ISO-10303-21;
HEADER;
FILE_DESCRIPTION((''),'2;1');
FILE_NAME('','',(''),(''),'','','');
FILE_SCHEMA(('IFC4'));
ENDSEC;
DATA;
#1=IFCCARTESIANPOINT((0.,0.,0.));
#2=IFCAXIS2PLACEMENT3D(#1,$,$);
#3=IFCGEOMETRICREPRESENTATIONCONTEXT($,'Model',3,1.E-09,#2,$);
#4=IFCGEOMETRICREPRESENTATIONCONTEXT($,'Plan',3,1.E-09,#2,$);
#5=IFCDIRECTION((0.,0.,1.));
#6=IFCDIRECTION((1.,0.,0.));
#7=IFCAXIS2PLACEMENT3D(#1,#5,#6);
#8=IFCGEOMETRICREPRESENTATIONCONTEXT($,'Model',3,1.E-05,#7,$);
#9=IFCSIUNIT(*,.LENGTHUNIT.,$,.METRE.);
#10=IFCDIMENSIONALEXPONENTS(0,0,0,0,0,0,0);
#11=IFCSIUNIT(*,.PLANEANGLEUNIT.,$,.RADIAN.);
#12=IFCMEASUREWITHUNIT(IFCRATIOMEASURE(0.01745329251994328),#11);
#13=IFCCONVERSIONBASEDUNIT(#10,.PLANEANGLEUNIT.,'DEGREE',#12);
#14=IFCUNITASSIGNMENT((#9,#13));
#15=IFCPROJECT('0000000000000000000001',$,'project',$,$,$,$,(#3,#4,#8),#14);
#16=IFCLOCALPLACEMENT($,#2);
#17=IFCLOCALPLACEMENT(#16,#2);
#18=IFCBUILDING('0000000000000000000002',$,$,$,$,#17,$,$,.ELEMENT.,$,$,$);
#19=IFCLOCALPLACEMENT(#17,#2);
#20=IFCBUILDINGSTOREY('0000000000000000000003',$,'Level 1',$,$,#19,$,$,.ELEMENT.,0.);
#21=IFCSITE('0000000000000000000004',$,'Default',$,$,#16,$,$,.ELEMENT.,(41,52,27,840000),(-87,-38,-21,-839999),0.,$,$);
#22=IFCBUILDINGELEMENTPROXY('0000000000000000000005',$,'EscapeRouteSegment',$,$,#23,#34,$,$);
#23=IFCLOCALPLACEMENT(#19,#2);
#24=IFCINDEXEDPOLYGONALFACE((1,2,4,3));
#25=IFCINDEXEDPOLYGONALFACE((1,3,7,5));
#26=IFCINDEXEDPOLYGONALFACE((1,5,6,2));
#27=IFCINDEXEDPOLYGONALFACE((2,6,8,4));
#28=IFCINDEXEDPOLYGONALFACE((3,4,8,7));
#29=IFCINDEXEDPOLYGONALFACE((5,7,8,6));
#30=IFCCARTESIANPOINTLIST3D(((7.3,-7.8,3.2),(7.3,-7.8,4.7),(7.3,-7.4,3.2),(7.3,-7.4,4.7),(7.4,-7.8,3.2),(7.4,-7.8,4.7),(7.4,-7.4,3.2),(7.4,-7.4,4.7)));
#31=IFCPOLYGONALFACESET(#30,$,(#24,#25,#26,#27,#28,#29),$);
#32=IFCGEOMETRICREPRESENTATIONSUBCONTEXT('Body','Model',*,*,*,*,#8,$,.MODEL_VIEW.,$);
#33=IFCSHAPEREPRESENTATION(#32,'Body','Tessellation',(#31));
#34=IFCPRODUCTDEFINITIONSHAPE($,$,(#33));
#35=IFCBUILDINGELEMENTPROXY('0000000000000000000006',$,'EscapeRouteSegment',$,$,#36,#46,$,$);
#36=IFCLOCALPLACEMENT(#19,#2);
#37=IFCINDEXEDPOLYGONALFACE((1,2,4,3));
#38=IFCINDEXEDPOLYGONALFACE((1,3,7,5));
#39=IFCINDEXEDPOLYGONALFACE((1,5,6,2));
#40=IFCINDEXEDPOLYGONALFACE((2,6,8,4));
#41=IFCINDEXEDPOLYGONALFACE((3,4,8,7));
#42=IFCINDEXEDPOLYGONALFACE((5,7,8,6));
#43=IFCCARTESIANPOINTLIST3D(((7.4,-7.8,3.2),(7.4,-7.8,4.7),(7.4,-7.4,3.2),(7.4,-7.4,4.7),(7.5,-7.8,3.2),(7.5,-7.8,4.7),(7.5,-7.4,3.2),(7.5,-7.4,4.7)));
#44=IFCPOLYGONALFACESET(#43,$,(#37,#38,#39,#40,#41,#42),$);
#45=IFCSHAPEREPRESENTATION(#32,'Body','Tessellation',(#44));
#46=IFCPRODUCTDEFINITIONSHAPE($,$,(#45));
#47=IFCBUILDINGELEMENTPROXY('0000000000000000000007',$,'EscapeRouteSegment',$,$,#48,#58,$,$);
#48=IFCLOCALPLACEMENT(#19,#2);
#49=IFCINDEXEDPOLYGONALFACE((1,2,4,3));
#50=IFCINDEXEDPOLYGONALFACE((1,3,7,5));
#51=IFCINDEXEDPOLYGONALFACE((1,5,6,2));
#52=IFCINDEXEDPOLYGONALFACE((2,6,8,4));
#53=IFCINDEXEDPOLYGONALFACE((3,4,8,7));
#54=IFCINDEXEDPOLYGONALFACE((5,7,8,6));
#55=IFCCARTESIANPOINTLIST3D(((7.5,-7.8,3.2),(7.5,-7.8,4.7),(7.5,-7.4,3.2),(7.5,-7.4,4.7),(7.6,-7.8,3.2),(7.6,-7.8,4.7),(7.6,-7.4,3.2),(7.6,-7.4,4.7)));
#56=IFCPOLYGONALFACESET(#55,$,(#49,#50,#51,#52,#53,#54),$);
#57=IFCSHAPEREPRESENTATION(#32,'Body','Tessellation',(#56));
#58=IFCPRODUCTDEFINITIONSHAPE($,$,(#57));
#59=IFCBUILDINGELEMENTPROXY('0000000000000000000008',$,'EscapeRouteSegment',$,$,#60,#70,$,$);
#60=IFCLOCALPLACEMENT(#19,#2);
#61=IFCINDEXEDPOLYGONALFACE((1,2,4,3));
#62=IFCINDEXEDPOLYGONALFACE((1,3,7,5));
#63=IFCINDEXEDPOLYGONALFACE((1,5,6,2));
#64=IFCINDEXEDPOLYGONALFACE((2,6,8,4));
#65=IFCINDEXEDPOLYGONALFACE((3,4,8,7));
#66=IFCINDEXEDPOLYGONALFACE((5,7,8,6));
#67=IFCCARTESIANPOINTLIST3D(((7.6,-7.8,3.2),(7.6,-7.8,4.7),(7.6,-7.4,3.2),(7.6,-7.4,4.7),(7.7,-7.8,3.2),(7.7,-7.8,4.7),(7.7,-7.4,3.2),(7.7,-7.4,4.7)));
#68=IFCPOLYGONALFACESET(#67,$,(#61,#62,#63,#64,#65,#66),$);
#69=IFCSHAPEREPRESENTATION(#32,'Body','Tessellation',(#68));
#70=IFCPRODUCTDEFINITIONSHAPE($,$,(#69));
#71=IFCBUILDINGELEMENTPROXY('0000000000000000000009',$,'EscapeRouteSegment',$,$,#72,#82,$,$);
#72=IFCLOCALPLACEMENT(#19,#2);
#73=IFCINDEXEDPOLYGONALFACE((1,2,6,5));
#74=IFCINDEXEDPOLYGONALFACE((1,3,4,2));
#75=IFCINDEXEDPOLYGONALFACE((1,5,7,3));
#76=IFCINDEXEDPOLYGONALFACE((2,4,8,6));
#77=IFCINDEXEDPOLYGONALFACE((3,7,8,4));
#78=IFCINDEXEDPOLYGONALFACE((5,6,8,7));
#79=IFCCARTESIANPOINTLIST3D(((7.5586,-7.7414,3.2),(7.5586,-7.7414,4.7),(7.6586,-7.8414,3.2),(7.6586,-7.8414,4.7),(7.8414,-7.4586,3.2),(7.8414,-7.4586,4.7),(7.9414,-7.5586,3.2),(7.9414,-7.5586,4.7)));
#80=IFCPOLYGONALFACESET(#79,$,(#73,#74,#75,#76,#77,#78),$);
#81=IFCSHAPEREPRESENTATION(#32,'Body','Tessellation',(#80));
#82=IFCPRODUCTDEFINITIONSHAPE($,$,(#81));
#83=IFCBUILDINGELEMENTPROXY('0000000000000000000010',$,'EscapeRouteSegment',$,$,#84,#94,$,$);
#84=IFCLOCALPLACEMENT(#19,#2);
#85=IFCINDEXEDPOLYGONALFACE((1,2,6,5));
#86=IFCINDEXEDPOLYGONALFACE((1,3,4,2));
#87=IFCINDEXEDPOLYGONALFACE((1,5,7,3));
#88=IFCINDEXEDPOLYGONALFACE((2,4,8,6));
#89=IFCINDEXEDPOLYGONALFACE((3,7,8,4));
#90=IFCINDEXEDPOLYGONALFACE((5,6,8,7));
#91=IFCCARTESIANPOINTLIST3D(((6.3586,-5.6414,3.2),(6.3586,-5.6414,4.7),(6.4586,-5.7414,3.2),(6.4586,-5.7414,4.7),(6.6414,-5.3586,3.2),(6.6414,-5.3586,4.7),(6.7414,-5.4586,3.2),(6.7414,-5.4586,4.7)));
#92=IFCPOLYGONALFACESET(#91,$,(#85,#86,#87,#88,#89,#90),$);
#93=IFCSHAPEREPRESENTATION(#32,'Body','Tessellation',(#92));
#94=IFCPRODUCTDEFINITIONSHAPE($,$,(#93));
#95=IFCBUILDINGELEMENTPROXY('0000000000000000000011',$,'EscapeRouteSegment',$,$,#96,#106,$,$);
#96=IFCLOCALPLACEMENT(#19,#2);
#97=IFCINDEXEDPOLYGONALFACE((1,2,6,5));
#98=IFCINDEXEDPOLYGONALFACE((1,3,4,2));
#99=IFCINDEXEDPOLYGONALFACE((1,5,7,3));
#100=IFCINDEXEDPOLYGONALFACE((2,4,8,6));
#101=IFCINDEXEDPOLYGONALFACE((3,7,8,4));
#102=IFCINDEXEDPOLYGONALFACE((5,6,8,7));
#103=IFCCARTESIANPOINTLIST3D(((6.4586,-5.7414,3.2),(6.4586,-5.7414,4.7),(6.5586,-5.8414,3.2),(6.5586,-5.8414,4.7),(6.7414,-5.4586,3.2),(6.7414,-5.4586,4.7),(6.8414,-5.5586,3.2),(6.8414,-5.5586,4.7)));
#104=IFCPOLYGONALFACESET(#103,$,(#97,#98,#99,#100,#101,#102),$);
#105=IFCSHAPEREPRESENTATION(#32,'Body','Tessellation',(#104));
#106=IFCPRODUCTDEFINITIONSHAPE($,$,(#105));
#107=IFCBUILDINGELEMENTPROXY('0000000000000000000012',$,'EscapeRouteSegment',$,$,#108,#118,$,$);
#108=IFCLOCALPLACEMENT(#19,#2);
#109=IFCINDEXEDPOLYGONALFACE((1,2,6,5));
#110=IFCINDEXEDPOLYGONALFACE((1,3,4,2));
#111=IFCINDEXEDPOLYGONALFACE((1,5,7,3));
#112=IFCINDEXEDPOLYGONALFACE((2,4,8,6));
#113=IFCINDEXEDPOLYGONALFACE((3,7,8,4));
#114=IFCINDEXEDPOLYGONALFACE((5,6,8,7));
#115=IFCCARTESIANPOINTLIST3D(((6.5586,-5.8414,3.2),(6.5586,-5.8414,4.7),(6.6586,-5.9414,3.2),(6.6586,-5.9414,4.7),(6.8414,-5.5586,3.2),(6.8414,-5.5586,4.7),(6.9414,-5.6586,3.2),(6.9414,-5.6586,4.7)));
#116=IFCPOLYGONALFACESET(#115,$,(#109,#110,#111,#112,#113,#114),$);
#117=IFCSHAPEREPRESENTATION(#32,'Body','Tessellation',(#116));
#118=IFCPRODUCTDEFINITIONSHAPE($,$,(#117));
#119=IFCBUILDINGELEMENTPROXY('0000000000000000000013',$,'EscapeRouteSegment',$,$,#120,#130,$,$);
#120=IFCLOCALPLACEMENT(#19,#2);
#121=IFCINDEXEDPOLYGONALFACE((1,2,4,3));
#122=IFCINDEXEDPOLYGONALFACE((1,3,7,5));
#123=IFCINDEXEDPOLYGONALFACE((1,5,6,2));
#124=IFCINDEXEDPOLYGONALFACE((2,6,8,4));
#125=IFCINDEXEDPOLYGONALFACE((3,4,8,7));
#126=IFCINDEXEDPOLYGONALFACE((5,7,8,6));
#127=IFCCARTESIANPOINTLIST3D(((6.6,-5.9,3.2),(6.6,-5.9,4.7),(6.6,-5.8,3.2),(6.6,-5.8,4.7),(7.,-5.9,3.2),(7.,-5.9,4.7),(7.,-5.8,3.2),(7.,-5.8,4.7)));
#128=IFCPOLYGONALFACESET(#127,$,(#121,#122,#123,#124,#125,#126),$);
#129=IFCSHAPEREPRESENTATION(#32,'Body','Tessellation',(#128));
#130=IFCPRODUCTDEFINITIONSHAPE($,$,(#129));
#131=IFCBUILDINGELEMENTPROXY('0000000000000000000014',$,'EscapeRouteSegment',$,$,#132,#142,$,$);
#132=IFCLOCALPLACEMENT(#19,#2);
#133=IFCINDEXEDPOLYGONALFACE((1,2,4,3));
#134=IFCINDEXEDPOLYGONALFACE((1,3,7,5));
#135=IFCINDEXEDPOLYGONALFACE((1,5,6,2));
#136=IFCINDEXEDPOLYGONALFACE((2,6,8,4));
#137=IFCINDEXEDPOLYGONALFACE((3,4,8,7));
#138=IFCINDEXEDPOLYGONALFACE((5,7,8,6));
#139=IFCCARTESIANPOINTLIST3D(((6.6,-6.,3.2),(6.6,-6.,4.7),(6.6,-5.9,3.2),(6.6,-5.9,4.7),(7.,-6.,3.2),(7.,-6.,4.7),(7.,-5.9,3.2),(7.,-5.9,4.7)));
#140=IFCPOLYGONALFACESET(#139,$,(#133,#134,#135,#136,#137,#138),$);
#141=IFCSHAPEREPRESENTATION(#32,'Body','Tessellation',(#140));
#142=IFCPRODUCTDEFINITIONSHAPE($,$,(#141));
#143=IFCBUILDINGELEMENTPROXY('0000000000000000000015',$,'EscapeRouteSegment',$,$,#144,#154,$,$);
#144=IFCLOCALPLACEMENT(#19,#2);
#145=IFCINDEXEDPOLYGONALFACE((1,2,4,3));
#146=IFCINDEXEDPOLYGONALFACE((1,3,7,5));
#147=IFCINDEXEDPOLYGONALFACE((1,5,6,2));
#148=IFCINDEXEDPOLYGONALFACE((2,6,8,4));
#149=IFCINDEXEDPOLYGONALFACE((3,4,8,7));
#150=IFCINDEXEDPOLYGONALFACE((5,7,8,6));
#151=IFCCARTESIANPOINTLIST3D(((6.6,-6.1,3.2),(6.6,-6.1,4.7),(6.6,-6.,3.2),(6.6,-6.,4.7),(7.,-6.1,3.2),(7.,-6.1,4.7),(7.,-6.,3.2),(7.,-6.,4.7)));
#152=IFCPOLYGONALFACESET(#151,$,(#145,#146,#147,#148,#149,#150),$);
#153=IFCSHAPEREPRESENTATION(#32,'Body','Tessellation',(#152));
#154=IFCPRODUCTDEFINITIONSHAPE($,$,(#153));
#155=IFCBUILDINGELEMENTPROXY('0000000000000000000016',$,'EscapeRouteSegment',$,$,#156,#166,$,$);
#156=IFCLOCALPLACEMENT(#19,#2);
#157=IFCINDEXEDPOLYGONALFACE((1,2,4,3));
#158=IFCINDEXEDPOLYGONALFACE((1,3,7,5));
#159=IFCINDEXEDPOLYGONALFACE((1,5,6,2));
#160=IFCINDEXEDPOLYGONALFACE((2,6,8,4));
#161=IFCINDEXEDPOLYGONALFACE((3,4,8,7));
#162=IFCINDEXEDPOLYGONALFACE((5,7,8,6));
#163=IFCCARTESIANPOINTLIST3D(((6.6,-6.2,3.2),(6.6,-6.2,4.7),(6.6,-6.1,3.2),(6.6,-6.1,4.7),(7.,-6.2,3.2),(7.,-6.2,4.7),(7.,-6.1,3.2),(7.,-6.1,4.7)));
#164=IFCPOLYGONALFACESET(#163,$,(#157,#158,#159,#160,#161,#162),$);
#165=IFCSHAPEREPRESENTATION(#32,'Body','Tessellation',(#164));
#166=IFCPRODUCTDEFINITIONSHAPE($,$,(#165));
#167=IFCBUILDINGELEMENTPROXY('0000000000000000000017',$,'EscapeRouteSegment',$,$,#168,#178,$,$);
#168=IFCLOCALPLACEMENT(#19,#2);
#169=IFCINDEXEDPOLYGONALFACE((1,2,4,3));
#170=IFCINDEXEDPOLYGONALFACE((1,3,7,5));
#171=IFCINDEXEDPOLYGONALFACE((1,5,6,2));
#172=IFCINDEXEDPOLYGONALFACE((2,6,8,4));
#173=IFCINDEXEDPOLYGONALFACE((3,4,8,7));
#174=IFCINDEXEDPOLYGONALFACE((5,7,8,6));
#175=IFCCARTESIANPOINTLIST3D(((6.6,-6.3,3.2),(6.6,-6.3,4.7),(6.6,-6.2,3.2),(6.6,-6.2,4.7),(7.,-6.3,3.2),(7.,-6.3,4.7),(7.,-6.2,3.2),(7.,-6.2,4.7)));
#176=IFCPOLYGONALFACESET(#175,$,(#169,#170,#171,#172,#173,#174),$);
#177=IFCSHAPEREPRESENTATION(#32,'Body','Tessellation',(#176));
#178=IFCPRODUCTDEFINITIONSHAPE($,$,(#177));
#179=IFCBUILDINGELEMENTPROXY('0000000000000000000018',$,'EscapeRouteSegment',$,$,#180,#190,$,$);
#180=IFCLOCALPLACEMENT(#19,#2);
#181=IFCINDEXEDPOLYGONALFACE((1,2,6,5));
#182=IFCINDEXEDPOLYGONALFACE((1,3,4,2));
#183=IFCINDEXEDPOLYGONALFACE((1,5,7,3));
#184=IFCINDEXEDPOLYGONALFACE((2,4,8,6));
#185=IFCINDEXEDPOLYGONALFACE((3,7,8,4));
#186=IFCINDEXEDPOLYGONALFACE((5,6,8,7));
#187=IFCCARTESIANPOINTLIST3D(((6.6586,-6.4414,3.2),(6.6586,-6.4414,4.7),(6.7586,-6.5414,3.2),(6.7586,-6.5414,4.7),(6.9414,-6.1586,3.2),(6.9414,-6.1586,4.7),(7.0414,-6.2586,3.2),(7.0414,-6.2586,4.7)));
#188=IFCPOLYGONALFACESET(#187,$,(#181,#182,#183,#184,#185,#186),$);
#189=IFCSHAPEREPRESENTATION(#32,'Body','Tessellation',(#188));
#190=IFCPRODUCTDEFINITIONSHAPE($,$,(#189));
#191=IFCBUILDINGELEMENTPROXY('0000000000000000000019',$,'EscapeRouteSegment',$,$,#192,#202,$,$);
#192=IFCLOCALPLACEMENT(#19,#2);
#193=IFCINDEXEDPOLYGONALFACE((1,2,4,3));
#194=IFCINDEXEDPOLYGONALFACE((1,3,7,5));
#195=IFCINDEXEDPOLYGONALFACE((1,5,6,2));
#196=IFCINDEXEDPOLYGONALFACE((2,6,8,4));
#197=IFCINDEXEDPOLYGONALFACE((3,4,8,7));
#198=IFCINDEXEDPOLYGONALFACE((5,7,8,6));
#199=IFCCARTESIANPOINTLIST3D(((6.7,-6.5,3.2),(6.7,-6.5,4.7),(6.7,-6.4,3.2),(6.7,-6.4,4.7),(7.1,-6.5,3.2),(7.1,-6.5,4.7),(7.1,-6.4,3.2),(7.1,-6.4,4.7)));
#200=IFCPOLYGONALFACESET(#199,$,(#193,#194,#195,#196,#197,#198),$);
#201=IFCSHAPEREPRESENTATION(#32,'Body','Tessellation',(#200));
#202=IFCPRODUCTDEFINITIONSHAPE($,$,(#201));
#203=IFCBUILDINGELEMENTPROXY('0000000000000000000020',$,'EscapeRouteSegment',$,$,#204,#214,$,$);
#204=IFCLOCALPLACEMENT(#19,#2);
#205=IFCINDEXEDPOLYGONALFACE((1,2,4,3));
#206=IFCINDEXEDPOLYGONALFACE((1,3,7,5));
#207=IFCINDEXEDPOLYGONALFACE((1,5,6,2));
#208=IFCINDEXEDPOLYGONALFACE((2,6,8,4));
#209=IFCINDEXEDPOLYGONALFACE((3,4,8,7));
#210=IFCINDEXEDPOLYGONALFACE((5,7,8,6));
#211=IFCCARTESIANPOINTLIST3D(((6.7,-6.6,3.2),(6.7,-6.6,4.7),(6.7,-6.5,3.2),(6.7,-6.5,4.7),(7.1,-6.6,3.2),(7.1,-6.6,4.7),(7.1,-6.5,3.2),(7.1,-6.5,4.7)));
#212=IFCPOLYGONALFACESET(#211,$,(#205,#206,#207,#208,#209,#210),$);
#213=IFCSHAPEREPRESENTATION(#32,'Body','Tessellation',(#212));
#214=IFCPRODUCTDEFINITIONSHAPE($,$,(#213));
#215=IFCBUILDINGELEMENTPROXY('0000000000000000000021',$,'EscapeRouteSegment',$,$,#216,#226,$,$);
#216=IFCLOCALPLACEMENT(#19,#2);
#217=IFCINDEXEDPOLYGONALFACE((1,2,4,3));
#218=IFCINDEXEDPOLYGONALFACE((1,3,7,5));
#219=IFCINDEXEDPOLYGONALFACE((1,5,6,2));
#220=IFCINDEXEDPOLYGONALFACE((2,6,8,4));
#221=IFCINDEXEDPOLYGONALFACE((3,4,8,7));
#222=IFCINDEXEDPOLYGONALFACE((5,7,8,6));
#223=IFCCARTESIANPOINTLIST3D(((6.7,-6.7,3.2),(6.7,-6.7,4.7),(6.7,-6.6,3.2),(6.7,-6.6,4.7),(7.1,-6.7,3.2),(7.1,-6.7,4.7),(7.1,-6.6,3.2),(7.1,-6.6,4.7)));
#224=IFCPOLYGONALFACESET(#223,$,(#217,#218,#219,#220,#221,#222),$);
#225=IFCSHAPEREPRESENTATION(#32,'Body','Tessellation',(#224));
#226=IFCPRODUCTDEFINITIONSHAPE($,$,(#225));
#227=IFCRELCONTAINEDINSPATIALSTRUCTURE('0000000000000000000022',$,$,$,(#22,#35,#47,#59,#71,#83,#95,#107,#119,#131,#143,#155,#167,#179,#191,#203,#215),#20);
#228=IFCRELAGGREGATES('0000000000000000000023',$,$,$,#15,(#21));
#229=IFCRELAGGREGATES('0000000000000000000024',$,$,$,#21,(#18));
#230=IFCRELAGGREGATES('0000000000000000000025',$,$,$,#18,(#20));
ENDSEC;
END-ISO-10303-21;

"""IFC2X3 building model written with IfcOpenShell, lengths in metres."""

from ifc_helpers import new_model, entity, si_unit, converted_unit, frame, origin, origin_with_axes, place, context, subcontext, project, spatial, polyline, outline, extrude, element, save


model = new_model("IFC2X3")

# Units and contexts
model_context_1 = context("Model", 3, precision=1e-09, world=origin())
plan_context = context("Plan", 3, precision=1e-09, world=origin())
model_context_2 = context("Model", 3, precision=1e-05, world=origin_with_axes())
body_context = subcontext(model_context_2, "Body", "Model", "MODEL_VIEW")
ifc_project = project(units=[si_unit("LENGTHUNIT", "METRE"), converted_unit("PLANEANGLEUNIT", "DEGREE", entity("IfcRatioMeasure", 0.01745329251994328), si_unit("PLANEANGLEUNIT", "RADIAN"), dimensions=[0, 0, 0, 0, 0, 0, 0])], contexts=[model_context_1, plan_context, model_context_2])

# Site, building, storey
site_placement = place(None, origin())
site = spatial("IfcSite", under=ifc_project, at=site_placement, Name="Default", CompositionType="ELEMENT", RefLatitude=(41, 52, 27, 840000), RefLongitude=(-87, -38, -21, -839999), RefElevation=0.0)
building_placement = place(site_placement, origin())
building = spatial("IfcBuilding", under=site, at=building_placement, CompositionType="ELEMENT")
storey_placement = place(building_placement, origin())
storey = spatial("IfcBuildingStorey", under=building, at=storey_placement, Name="Level 1", CompositionType="ELEMENT", Elevation=0.0)

# Building element proxies
for number, where, z_axis, x_axis, name in (
    (1, (7.3, -7.6, 3.2), (0.0, 0.0, 1.0), (1.0, 0.0, 0.0), "EscapeRouteSegment"),
    (2, (7.4, -7.6, 3.2), (0.0, 0.0, 1.0), (1.0, 0.0, 0.0), "EscapeRouteSegment"),
    (3, (7.5, -7.6, 3.2), (0.0, 0.0, 1.0), (1.0, 0.0, 0.0), "EscapeRouteSegment"),
    (4, (7.6, -7.6, 3.2), (0.0, 0.0, 1.0), (1.0, 0.0, 0.0), "EscapeRouteSegment"),
):
    element("IfcBuildingElementProxy", number, at=place(storey_placement, frame(where, z_axis=z_axis, x_axis=x_axis)), inside=storey, Name=name, context=body_context, shape_type="SweptSolid", body=[
        extrude(outline(polyline([(0.0, -0.2), (0.0, 0.2), (0.1, 0.2), (0.1, -0.2), (0.0, -0.2)])), origin_with_axes(), (0.0, 0.0, 1.0), 1.5),
    ])
proxy_1_placement = place(storey_placement, frame((7.7, -7.6, 3.2), z_axis=(0.0, 0.0, 1.0), x_axis=(0.707108, -0.707105, 0.0)))
element("IfcBuildingElementProxy", 5, at=proxy_1_placement, inside=storey, Name="EscapeRouteSegment", context=body_context, shape_type="SweptSolid", body=[
    extrude(outline(polyline([(0.0, -0.2), (0.0, 0.2), (0.1414, 0.2), (0.1414, -0.2), (0.0, -0.2)])), origin_with_axes(), (0.0, 0.0, 1.0), 1.5),
])
for number, where, z_axis, x_axis, name in (
    (6, (6.5, -5.5, 3.2), (0.0, 0.0, 1.0), (0.707107, -0.707107, 0.0), "EscapeRouteSegment"),
    (7, (6.6, -5.6, 3.2), (0.0, 0.0, 1.0), (0.707107, -0.707107, 0.0), "EscapeRouteSegment"),
):
    element("IfcBuildingElementProxy", number, at=place(storey_placement, frame(where, z_axis=z_axis, x_axis=x_axis)), inside=storey, Name=name, context=body_context, shape_type="SweptSolid", body=[
        extrude(outline(polyline([(0.0, -0.2), (0.0, 0.2), (0.1414, 0.2), (0.1414, -0.2), (0.0, -0.2)])), origin_with_axes(), (0.0, 0.0, 1.0), 1.5),
    ])
proxy_2_placement = place(storey_placement, frame((6.7, -5.7, 3.2), z_axis=(0.0, 0.0, 1.0), x_axis=(0.707107, -0.707107, 0.0)))
element("IfcBuildingElementProxy", 8, at=proxy_2_placement, inside=storey, Name="EscapeRouteSegment", context=body_context, shape_type="SweptSolid", body=[
    extrude(outline(polyline([(0.0, -0.2), (0.0, 0.2), (0.1414, 0.2), (0.1414, -0.2), (0.0, -0.2)])), origin_with_axes(), (0.0, 0.0, 1.0), 1.5),
])
for number, where, z_axis, x_axis, name in (
    (9, (6.8, -5.8, 3.2), (0.0, 0.0, 1.0), (0.0, -1.0, 0.0), "EscapeRouteSegment"),
    (10, (6.8, -5.9, 3.2), (0.0, 0.0, 1.0), (0.0, -1.0, 0.0), "EscapeRouteSegment"),
    (11, (6.8, -6.0, 3.2), (0.0, 0.0, 1.0), (0.0, -1.0, 0.0), "EscapeRouteSegment"),
    (12, (6.8, -6.1, 3.2), (0.0, 0.0, 1.0), (0.0, -1.0, 0.0), "EscapeRouteSegment"),
):
    element("IfcBuildingElementProxy", number, at=place(storey_placement, frame(where, z_axis=z_axis, x_axis=x_axis)), inside=storey, Name=name, context=body_context, shape_type="SweptSolid", body=[
        extrude(outline(polyline([(0.0, -0.2), (0.0, 0.2), (0.1, 0.2), (0.1, -0.2), (0.0, -0.2)])), origin_with_axes(), (0.0, 0.0, 1.0), 1.5),
    ])
proxy_3_placement = place(storey_placement, frame((6.8, -6.2, 3.2), z_axis=(0.0, 0.0, 1.0), x_axis=(0.0, -1.0, 0.0)))
element("IfcBuildingElementProxy", 13, at=proxy_3_placement, inside=storey, Name="EscapeRouteSegment", context=body_context, shape_type="SweptSolid", body=[
    extrude(outline(polyline([(0.0, -0.2), (0.0, 0.2), (0.1, 0.2), (0.1, -0.2), (0.0, -0.2)])), origin_with_axes(), (0.0, 0.0, 1.0), 1.5),
])
proxy_4_placement = place(storey_placement, frame((6.8, -6.3, 3.2), z_axis=(0.0, 0.0, 1.0), x_axis=(0.707107, -0.707107, 0.0)))
element("IfcBuildingElementProxy", 14, at=proxy_4_placement, inside=storey, Name="EscapeRouteSegment", context=body_context, shape_type="SweptSolid", body=[
    extrude(outline(polyline([(0.0, -0.2), (0.0, 0.2), (0.1414, 0.2), (0.1414, -0.2), (0.0, -0.2)])), origin_with_axes(), (0.0, 0.0, 1.0), 1.5),
])
for number, where, z_axis, x_axis, name in (
    (15, (6.9, -6.4, 3.2), (0.0, 0.0, 1.0), (0.0, -1.0, 0.0), "EscapeRouteSegment"),
    (16, (6.9, -6.5, 3.2), (0.0, 0.0, 1.0), (0.0, -1.0, 0.0), "EscapeRouteSegment"),
    (17, (6.9, -6.6, 3.2), (0.0, 0.0, 1.0), (0.0, -1.0, 0.0), "EscapeRouteSegment"),
):
    element("IfcBuildingElementProxy", number, at=place(storey_placement, frame(where, z_axis=z_axis, x_axis=x_axis)), inside=storey, Name=name, context=body_context, shape_type="SweptSolid", body=[
        extrude(outline(polyline([(0.0, -0.2), (0.0, 0.2), (0.1, 0.2), (0.1, -0.2), (0.0, -0.2)])), origin_with_axes(), (0.0, 0.0, 1.0), 1.5),
    ])

save(model, "model.ifc")
